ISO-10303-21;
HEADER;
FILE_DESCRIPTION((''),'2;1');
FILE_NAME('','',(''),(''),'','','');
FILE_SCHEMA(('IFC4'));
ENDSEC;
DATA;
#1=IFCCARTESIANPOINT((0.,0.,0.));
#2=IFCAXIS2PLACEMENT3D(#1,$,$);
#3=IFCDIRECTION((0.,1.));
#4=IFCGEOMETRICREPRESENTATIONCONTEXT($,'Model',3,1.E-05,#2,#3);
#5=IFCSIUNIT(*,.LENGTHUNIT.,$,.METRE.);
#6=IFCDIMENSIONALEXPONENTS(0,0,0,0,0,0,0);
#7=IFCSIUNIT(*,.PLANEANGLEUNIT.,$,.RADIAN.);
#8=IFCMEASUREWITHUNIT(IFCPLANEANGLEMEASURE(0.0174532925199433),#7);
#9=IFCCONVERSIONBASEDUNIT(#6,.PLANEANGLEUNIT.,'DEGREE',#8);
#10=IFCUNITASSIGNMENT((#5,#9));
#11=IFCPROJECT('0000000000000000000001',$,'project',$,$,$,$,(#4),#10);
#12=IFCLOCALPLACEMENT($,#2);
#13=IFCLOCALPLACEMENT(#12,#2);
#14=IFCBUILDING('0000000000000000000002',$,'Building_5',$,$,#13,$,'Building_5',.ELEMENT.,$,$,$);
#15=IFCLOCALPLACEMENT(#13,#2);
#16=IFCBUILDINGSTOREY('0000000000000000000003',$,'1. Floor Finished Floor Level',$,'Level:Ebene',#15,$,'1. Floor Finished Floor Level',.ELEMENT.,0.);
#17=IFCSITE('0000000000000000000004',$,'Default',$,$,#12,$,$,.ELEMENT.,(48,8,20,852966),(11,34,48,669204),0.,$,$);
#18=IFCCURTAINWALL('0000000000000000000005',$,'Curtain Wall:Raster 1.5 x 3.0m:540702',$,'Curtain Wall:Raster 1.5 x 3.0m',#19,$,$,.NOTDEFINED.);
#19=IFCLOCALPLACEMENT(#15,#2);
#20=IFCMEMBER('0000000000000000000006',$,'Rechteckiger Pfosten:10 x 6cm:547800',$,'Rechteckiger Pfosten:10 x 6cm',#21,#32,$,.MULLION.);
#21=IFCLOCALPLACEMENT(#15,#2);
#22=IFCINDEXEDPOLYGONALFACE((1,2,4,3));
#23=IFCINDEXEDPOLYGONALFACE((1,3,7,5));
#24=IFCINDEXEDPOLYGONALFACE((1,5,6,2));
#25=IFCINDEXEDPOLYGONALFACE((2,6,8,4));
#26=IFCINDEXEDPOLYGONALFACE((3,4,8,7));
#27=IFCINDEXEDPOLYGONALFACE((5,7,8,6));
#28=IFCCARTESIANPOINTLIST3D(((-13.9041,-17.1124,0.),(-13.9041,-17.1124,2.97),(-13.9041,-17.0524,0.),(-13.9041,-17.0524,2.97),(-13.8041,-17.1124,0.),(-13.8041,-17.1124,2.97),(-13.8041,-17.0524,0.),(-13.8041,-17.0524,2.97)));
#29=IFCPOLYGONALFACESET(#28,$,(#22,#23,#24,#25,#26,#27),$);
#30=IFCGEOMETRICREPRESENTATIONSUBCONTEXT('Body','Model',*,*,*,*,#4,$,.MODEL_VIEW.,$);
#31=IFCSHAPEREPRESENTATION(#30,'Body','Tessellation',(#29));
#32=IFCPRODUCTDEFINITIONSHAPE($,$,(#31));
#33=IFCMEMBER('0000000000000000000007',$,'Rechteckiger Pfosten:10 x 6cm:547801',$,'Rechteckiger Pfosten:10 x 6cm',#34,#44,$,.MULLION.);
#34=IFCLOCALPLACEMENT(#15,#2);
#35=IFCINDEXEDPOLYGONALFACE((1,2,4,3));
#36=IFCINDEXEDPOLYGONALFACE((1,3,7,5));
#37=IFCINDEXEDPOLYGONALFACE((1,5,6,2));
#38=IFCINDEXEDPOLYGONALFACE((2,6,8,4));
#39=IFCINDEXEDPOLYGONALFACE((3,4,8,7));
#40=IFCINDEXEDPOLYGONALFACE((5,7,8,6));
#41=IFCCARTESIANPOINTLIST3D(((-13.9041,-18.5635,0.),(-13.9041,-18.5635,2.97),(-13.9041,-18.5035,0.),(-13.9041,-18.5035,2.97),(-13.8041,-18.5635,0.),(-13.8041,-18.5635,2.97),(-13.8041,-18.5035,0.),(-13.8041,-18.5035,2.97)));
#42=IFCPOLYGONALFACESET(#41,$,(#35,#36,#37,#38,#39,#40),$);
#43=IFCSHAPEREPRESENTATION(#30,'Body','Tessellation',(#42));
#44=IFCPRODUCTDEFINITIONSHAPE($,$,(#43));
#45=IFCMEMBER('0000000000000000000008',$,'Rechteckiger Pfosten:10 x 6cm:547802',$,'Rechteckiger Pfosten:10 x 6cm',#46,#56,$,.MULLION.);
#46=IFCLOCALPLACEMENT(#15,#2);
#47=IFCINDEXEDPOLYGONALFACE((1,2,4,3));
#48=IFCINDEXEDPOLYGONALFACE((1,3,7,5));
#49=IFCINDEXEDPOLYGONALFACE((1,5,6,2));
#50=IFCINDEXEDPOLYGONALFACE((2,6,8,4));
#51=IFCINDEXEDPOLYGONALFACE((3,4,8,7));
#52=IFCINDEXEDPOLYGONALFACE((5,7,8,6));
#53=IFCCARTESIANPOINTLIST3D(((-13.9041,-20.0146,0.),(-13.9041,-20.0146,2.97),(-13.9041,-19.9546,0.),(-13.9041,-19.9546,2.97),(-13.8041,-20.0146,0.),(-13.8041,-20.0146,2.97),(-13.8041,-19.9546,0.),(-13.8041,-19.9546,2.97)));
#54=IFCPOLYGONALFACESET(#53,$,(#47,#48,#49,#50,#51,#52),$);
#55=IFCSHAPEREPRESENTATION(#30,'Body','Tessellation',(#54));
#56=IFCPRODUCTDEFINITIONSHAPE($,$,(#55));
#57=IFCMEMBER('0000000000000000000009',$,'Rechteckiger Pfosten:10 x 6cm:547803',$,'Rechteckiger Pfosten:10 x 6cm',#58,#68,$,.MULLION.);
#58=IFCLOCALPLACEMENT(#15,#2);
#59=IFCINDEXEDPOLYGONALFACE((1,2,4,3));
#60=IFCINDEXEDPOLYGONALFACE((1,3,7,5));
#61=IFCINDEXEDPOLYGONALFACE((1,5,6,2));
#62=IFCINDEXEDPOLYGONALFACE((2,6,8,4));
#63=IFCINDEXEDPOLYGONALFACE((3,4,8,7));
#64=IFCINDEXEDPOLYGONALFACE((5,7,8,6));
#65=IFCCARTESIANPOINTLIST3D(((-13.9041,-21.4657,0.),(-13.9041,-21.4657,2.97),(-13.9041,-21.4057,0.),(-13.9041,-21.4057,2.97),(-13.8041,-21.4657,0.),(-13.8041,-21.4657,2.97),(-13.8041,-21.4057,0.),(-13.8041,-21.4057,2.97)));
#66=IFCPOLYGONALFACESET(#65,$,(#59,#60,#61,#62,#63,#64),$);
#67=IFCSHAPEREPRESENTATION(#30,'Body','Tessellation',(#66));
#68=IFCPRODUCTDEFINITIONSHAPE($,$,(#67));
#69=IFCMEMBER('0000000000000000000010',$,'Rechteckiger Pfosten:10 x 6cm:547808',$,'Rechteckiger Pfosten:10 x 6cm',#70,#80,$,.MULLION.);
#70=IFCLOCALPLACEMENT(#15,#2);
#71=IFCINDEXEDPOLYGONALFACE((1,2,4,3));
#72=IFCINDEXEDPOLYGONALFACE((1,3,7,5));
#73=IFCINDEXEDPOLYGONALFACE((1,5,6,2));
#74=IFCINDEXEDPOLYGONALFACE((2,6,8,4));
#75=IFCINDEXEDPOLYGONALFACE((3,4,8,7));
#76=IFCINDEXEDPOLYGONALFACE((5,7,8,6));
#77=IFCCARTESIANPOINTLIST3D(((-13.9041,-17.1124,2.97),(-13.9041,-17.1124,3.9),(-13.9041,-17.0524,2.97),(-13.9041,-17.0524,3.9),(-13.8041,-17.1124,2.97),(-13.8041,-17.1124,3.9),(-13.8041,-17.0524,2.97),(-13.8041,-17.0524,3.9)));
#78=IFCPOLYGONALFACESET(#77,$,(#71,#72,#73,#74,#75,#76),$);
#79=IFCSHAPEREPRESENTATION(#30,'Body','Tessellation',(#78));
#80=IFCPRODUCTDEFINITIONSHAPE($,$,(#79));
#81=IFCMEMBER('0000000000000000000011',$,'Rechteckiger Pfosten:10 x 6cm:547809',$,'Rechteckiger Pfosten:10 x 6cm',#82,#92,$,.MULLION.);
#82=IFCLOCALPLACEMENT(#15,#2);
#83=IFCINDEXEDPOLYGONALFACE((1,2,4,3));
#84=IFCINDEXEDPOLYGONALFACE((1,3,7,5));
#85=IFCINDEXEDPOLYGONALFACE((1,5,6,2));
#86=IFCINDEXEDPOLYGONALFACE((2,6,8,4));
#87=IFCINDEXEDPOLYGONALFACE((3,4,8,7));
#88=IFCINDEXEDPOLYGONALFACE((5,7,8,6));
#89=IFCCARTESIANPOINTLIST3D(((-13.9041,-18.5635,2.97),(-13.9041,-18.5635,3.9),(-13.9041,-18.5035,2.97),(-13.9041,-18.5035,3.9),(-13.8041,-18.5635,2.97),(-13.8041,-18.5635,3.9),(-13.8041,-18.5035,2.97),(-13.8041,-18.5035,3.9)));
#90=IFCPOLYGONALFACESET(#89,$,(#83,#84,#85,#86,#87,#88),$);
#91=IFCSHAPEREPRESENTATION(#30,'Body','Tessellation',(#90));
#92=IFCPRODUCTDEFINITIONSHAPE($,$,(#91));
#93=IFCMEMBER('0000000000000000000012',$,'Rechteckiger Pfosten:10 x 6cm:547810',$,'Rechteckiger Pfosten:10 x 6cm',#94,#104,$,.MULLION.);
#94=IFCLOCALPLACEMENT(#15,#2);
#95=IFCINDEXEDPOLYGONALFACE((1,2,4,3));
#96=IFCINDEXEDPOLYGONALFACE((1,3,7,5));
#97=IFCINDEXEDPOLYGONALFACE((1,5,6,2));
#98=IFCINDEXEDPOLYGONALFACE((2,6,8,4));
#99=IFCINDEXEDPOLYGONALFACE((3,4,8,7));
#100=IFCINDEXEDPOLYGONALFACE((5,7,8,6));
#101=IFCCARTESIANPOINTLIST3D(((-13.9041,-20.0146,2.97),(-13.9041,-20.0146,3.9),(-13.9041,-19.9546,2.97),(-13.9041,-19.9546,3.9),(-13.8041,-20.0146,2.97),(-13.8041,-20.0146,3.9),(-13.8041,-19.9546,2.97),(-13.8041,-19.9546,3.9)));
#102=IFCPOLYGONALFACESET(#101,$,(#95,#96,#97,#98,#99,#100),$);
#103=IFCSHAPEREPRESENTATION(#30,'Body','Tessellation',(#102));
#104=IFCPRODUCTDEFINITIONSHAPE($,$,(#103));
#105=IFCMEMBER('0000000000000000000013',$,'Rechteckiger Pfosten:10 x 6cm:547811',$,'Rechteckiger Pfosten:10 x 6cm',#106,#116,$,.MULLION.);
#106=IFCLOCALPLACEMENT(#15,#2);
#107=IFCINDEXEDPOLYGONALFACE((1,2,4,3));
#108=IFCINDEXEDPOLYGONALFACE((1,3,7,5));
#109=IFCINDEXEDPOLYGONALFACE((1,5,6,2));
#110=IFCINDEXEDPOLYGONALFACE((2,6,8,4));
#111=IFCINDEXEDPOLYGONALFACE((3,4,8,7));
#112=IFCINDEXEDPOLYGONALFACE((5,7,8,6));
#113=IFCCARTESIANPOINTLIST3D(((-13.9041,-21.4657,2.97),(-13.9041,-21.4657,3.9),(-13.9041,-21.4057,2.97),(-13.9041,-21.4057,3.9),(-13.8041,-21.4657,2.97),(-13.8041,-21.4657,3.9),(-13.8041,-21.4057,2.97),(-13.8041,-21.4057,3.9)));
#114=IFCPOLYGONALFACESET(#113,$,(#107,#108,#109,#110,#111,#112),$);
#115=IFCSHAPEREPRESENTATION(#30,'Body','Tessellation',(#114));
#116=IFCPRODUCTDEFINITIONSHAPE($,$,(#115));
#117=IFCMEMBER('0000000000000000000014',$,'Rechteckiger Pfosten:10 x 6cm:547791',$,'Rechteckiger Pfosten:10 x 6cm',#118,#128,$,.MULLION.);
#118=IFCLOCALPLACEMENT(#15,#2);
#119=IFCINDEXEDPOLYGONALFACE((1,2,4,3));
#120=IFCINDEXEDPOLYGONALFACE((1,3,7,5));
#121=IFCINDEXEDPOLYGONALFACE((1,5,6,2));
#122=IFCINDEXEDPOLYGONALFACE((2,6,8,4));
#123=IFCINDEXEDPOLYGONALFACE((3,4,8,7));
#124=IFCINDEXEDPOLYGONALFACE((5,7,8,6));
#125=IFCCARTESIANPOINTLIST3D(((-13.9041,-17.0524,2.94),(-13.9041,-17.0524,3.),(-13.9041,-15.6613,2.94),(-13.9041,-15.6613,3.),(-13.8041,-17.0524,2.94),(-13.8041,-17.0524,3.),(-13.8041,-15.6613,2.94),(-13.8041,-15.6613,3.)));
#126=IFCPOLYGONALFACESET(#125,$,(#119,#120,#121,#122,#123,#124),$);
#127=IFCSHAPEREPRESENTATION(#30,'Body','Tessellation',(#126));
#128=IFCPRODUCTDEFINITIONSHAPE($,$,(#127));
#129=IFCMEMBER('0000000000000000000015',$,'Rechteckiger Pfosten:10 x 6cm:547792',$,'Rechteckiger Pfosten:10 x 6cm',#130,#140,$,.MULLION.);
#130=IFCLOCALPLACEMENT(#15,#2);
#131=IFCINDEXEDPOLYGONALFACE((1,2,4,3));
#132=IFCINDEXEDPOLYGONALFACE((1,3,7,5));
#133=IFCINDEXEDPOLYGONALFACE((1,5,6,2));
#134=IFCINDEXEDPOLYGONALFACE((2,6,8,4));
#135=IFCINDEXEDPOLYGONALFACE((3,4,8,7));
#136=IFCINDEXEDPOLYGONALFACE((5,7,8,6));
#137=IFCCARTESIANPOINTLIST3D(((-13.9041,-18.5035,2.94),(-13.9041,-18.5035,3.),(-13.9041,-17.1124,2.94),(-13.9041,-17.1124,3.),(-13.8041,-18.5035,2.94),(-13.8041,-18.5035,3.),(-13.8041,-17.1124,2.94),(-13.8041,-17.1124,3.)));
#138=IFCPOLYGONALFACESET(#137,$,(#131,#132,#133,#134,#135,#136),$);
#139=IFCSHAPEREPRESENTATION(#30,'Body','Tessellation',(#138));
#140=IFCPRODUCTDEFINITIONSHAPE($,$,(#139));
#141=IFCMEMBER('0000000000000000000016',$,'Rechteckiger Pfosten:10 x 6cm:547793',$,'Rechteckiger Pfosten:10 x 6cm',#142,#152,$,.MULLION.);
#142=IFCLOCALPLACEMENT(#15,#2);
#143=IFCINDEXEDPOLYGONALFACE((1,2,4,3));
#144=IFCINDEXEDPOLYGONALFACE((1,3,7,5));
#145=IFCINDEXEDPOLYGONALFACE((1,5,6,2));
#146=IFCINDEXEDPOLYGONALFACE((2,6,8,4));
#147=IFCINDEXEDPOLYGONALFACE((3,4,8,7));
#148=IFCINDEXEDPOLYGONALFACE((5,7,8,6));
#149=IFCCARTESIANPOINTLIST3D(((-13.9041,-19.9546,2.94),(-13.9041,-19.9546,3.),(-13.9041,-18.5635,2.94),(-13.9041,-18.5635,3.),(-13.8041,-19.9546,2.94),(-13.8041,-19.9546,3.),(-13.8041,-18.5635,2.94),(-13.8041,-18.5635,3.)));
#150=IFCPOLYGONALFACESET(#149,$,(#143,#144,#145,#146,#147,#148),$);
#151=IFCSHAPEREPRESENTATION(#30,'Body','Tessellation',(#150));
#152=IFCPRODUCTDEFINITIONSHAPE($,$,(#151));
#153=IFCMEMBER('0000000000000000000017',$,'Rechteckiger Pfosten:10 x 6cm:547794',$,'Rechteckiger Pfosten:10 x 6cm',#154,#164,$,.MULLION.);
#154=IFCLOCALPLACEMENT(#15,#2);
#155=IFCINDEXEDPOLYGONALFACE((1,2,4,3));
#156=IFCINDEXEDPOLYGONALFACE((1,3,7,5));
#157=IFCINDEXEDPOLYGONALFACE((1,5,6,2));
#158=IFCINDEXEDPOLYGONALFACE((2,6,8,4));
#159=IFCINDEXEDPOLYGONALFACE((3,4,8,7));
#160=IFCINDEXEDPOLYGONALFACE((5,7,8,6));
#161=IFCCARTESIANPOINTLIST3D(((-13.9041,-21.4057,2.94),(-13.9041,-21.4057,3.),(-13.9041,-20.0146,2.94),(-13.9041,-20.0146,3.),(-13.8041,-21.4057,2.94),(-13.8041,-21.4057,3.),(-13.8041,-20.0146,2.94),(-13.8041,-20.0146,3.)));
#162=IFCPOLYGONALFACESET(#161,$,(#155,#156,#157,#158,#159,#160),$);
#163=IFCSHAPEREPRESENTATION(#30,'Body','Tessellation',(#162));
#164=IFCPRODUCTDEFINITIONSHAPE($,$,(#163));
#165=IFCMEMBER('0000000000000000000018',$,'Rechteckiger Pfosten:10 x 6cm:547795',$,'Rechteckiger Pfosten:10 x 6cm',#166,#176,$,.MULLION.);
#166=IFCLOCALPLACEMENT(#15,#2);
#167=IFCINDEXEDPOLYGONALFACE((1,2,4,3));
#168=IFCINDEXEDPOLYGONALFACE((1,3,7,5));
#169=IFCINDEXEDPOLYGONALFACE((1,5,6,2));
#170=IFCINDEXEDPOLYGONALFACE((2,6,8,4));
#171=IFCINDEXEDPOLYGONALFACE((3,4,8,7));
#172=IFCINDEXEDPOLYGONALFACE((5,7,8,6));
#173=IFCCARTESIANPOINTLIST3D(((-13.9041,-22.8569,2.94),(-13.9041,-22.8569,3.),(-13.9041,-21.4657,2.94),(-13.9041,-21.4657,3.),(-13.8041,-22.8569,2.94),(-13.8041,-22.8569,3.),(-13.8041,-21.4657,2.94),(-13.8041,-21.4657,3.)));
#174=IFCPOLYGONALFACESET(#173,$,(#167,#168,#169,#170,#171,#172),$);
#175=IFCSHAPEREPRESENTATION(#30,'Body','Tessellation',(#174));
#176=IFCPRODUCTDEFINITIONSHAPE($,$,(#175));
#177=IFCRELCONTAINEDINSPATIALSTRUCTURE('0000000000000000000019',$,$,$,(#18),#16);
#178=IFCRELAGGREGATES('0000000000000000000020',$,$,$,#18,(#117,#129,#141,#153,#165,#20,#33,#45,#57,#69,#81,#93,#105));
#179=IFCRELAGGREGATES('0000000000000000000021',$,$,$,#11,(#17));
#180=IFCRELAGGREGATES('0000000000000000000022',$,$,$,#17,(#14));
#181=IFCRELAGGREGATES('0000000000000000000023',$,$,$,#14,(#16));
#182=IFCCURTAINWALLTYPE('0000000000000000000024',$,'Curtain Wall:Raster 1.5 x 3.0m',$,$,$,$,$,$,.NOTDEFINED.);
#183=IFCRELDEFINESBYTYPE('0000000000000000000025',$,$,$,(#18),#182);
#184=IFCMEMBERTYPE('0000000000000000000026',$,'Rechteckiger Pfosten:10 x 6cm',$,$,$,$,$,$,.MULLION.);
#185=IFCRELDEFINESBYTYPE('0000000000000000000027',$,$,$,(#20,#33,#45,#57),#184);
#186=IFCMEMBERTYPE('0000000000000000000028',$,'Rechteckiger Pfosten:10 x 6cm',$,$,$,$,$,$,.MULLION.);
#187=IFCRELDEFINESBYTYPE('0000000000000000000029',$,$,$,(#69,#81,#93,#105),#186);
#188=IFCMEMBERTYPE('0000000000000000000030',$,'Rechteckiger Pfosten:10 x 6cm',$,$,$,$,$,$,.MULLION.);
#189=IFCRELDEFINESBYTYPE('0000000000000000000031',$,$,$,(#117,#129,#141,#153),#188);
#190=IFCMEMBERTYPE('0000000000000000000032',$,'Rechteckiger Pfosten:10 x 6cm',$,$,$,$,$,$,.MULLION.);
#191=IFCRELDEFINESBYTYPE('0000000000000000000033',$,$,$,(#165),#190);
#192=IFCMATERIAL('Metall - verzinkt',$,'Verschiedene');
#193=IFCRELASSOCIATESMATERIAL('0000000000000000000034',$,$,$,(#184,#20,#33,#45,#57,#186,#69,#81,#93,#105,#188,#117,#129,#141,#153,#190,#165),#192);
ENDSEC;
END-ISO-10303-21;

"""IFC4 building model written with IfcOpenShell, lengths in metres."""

from ifc_helpers import new_model, entity, si_unit, converted_unit, direction, frame, origin, place, context, subcontext, project, spatial, indexed_curve, outline, extrude, source, transform, mapped, material, type_object, type_shapes, element, aggregate, save


model = new_model("IFC4")

# Units and contexts
model_context = context("Model", 3, precision=1e-05, world=origin(), true_north=direction((0.0, 1.0)))
body_context = subcontext(model_context, "Body", "Model", "MODEL_VIEW")
ifc_project = project(units=[si_unit("LENGTHUNIT", "METRE"), converted_unit("PLANEANGLEUNIT", "DEGREE", entity("IfcPlaneAngleMeasure", 0.0174532925199433), si_unit("PLANEANGLEUNIT", "RADIAN"), dimensions=[0, 0, 0, 0, 0, 0, 0])], contexts=[model_context])

# Site, building, storey
site_placement = place(None, origin())
site = spatial("IfcSite", under=ifc_project, at=site_placement, Name="Default", CompositionType="ELEMENT", RefLatitude=(48, 8, 20, 852966), RefLongitude=(11, 34, 48, 669204), RefElevation=0.0)
building_placement = place(site_placement, origin())
building = spatial("IfcBuilding", under=site, at=building_placement, Name="Building_5", LongName="Building_5", CompositionType="ELEMENT")
storey_placement = place(building_placement, origin())
storey = spatial("IfcBuildingStorey", under=building, at=storey_placement, Name="1. Floor Finished Floor Level", ObjectType="Level:Ebene", LongName="1. Floor Finished Floor Level", CompositionType="ELEMENT", Elevation=0.0)

# Curtain wall, members
curtain_wall_type = type_object("IfcCurtainWallType", Name="Curtain Wall:Raster 1.5 x 3.0m", PredefinedType="NOTDEFINED")
curtain_wall_placement = place(storey_placement, origin())
curtain_wall = element("IfcCurtainWall", 1, at=curtain_wall_placement, inside=storey, type_object=curtain_wall_type, Name="Curtain Wall:Raster 1.5 x 3.0m:540702", ObjectType="Curtain Wall:Raster 1.5 x 3.0m", PredefinedType="NOTDEFINED")
ifc_material_1 = material(Name="Metall - verzinkt", Category="Verschiedene")
member_type_1 = type_object("IfcMemberType", Name="Rechteckiger Pfosten:10 x 6cm", PredefinedType="MULLION", material=ifc_material_1)
shared_shape_1 = source(origin(), body_context, "Body", "SweptSolid", [
    extrude(outline(indexed_curve([(-0.03, -0.05), (0.03, -0.05), (0.03, 0.05), (-0.03, 0.05), (-0.03, -0.05)], self_intersect=False)), frame((0.0, 0.0, -2.97), z_axis=(0.0, 0.0, 1.0), x_axis=(-1.0, 0.0, 0.0)), (0.0, 0.0, 1.0), 2.97),
])
type_shapes(member_type_1, [shared_shape_1])
member_1_placement = place(curtain_wall_placement, frame((-13.8541, -17.0824, 0.0), z_axis=(0.0, 0.0, -1.0), x_axis=(0.0, -1.0, 0.0)))
member_1 = element("IfcMember", 2, at=member_1_placement, type_object=member_type_1, material=ifc_material_1, Name="Rechteckiger Pfosten:10 x 6cm:547800", ObjectType="Rechteckiger Pfosten:10 x 6cm", PredefinedType="MULLION", context=body_context, shape_type="MappedRepresentation", body=[
    mapped(shared_shape_1, transform((0.0, 0.0, 0.0), scale=1.0)),
])
member_2_placement = place(curtain_wall_placement, frame((-13.8541, -18.5335, 0.0), z_axis=(0.0, 0.0, -1.0), x_axis=(0.0, -1.0, 0.0)))
member_2 = element("IfcMember", 3, at=member_2_placement, type_object=member_type_1, material=ifc_material_1, Name="Rechteckiger Pfosten:10 x 6cm:547801", ObjectType="Rechteckiger Pfosten:10 x 6cm", PredefinedType="MULLION", context=body_context, shape_type="MappedRepresentation", body=[
    mapped(shared_shape_1, transform((0.0, 0.0, 0.0), scale=1.0)),
])
member_3_placement = place(curtain_wall_placement, frame((-13.8541, -19.9846, 0.0), z_axis=(0.0, 0.0, -1.0), x_axis=(0.0, -1.0, 0.0)))
member_3 = element("IfcMember", 4, at=member_3_placement, type_object=member_type_1, material=ifc_material_1, Name="Rechteckiger Pfosten:10 x 6cm:547802", ObjectType="Rechteckiger Pfosten:10 x 6cm", PredefinedType="MULLION", context=body_context, shape_type="MappedRepresentation", body=[
    mapped(shared_shape_1, transform((0.0, 0.0, 0.0), scale=1.0)),
])
member_4_placement = place(curtain_wall_placement, frame((-13.8541, -21.4357, 0.0), z_axis=(0.0, 0.0, -1.0), x_axis=(0.0, -1.0, 0.0)))
member_4 = element("IfcMember", 5, at=member_4_placement, type_object=member_type_1, material=ifc_material_1, Name="Rechteckiger Pfosten:10 x 6cm:547803", ObjectType="Rechteckiger Pfosten:10 x 6cm", PredefinedType="MULLION", context=body_context, shape_type="MappedRepresentation", body=[
    mapped(shared_shape_1, transform((0.0, 0.0, 0.0), scale=1.0)),
])
member_type_2 = type_object("IfcMemberType", Name="Rechteckiger Pfosten:10 x 6cm", PredefinedType="MULLION", material=ifc_material_1)
shared_shape_2 = source(origin(), body_context, "Body", "SweptSolid", [
    extrude(outline(indexed_curve([(-0.03, -0.05), (0.03, -0.05), (0.03, 0.05), (-0.03, 0.05), (-0.03, -0.05)], self_intersect=False)), frame((0.0, 0.0, -0.93), z_axis=(0.0, 0.0, 1.0), x_axis=(-1.0, 0.0, 0.0)), (0.0, 0.0, 1.0), 0.93),
])
type_shapes(member_type_2, [shared_shape_2])
member_5_placement = place(curtain_wall_placement, frame((-13.8541, -17.0824, 2.97), z_axis=(0.0, 0.0, -1.0), x_axis=(0.0, -1.0, 0.0)))
member_5 = element("IfcMember", 6, at=member_5_placement, type_object=member_type_2, material=ifc_material_1, Name="Rechteckiger Pfosten:10 x 6cm:547808", ObjectType="Rechteckiger Pfosten:10 x 6cm", PredefinedType="MULLION", context=body_context, shape_type="MappedRepresentation", body=[
    mapped(shared_shape_2, transform((0.0, 0.0, 0.0), scale=1.0)),
])
member_6_placement = place(curtain_wall_placement, frame((-13.8541, -18.5335, 2.97), z_axis=(0.0, 0.0, -1.0), x_axis=(0.0, -1.0, 0.0)))
member_6 = element("IfcMember", 7, at=member_6_placement, type_object=member_type_2, material=ifc_material_1, Name="Rechteckiger Pfosten:10 x 6cm:547809", ObjectType="Rechteckiger Pfosten:10 x 6cm", PredefinedType="MULLION", context=body_context, shape_type="MappedRepresentation", body=[
    mapped(shared_shape_2, transform((0.0, 0.0, 0.0), scale=1.0)),
])
member_7_placement = place(curtain_wall_placement, frame((-13.8541, -19.9846, 2.97), z_axis=(0.0, 0.0, -1.0), x_axis=(0.0, -1.0, 0.0)))
member_7 = element("IfcMember", 8, at=member_7_placement, type_object=member_type_2, material=ifc_material_1, Name="Rechteckiger Pfosten:10 x 6cm:547810", ObjectType="Rechteckiger Pfosten:10 x 6cm", PredefinedType="MULLION", context=body_context, shape_type="MappedRepresentation", body=[
    mapped(shared_shape_2, transform((0.0, 0.0, 0.0), scale=1.0)),
])
member_8_placement = place(curtain_wall_placement, frame((-13.8541, -21.4357, 2.97), z_axis=(0.0, 0.0, -1.0), x_axis=(0.0, -1.0, 0.0)))
member_8 = element("IfcMember", 9, at=member_8_placement, type_object=member_type_2, material=ifc_material_1, Name="Rechteckiger Pfosten:10 x 6cm:547811", ObjectType="Rechteckiger Pfosten:10 x 6cm", PredefinedType="MULLION", context=body_context, shape_type="MappedRepresentation", body=[
    mapped(shared_shape_2, transform((0.0, 0.0, 0.0), scale=1.0)),
])
member_type_3 = type_object("IfcMemberType", Name="Rechteckiger Pfosten:10 x 6cm", PredefinedType="MULLION", material=ifc_material_1)
shared_shape_3 = source(origin(), body_context, "Body", "SweptSolid", [
    extrude(outline(indexed_curve([(-0.03, -0.05), (0.03, -0.05), (0.03, 0.05), (-0.03, 0.05), (-0.03, -0.05)], self_intersect=False)), frame((0.0, 0.0, -1.3911), z_axis=(0.0, 0.0, 1.0), x_axis=(-1.0, 0.0, 0.0)), (0.0, 0.0, 1.0), 1.3911),
])
type_shapes(member_type_3, [shared_shape_3])
member_9_placement = place(curtain_wall_placement, frame((-13.8541, -17.0524, 2.97), z_axis=(0.0, -1.0, 0.0), x_axis=(0.0, 0.0, 1.0)))
member_9 = element("IfcMember", 10, at=member_9_placement, type_object=member_type_3, material=ifc_material_1, Name="Rechteckiger Pfosten:10 x 6cm:547791", ObjectType="Rechteckiger Pfosten:10 x 6cm", PredefinedType="MULLION", context=body_context, shape_type="MappedRepresentation", body=[
    mapped(shared_shape_3, transform((0.0, 0.0, 0.0), scale=1.0)),
])
member_10_placement = place(curtain_wall_placement, frame((-13.8541, -18.5035, 2.97), z_axis=(0.0, -1.0, 0.0), x_axis=(0.0, 0.0, 1.0)))
member_10 = element("IfcMember", 11, at=member_10_placement, type_object=member_type_3, material=ifc_material_1, Name="Rechteckiger Pfosten:10 x 6cm:547792", ObjectType="Rechteckiger Pfosten:10 x 6cm", PredefinedType="MULLION", context=body_context, shape_type="MappedRepresentation", body=[
    mapped(shared_shape_3, transform((0.0, 0.0, 0.0), scale=1.0)),
])
member_11_placement = place(curtain_wall_placement, frame((-13.8541, -19.9546, 2.97), z_axis=(0.0, -1.0, 0.0), x_axis=(0.0, 0.0, 1.0)))
member_11 = element("IfcMember", 12, at=member_11_placement, type_object=member_type_3, material=ifc_material_1, Name="Rechteckiger Pfosten:10 x 6cm:547793", ObjectType="Rechteckiger Pfosten:10 x 6cm", PredefinedType="MULLION", context=body_context, shape_type="MappedRepresentation", body=[
    mapped(shared_shape_3, transform((0.0, 0.0, 0.0), scale=1.0)),
])
member_12_placement = place(curtain_wall_placement, frame((-13.8541, -21.4057, 2.97), z_axis=(0.0, -1.0, 0.0), x_axis=(0.0, 0.0, 1.0)))
member_12 = element("IfcMember", 13, at=member_12_placement, type_object=member_type_3, material=ifc_material_1, Name="Rechteckiger Pfosten:10 x 6cm:547794", ObjectType="Rechteckiger Pfosten:10 x 6cm", PredefinedType="MULLION", context=body_context, shape_type="MappedRepresentation", body=[
    mapped(shared_shape_3, transform((0.0, 0.0, 0.0), scale=1.0)),
])
member_type_4 = type_object("IfcMemberType", Name="Rechteckiger Pfosten:10 x 6cm", PredefinedType="MULLION", material=ifc_material_1)
shared_shape_4 = source(origin(), body_context, "Body", "SweptSolid", [
    extrude(outline(indexed_curve([(-0.03, -0.05), (0.03, -0.05), (0.03, 0.05), (-0.03, 0.05), (-0.03, -0.05)], self_intersect=False)), frame((0.0, 0.0, -1.3911), z_axis=(0.0, 0.0, 1.0), x_axis=(-1.0, 0.0, 0.0)), (0.0, 0.0, 1.0), 1.3911),
])
type_shapes(member_type_4, [shared_shape_4])
member_13_placement = place(curtain_wall_placement, frame((-13.8541, -22.8569, 2.97), z_axis=(0.0, -1.0, 0.0), x_axis=(0.0, 0.0, 1.0)))
member_13 = element("IfcMember", 14, at=member_13_placement, type_object=member_type_4, material=ifc_material_1, Name="Rechteckiger Pfosten:10 x 6cm:547795", ObjectType="Rechteckiger Pfosten:10 x 6cm", PredefinedType="MULLION", context=body_context, shape_type="MappedRepresentation", body=[
    mapped(shared_shape_4, transform((0.0, 0.0, 0.0), scale=1.0)),
])
aggregate(curtain_wall, [member_9, member_10, member_11, member_12, member_13, member_1, member_2, member_3, member_4, member_5, member_6, member_7, member_8])

save(model, "model.ifc")
